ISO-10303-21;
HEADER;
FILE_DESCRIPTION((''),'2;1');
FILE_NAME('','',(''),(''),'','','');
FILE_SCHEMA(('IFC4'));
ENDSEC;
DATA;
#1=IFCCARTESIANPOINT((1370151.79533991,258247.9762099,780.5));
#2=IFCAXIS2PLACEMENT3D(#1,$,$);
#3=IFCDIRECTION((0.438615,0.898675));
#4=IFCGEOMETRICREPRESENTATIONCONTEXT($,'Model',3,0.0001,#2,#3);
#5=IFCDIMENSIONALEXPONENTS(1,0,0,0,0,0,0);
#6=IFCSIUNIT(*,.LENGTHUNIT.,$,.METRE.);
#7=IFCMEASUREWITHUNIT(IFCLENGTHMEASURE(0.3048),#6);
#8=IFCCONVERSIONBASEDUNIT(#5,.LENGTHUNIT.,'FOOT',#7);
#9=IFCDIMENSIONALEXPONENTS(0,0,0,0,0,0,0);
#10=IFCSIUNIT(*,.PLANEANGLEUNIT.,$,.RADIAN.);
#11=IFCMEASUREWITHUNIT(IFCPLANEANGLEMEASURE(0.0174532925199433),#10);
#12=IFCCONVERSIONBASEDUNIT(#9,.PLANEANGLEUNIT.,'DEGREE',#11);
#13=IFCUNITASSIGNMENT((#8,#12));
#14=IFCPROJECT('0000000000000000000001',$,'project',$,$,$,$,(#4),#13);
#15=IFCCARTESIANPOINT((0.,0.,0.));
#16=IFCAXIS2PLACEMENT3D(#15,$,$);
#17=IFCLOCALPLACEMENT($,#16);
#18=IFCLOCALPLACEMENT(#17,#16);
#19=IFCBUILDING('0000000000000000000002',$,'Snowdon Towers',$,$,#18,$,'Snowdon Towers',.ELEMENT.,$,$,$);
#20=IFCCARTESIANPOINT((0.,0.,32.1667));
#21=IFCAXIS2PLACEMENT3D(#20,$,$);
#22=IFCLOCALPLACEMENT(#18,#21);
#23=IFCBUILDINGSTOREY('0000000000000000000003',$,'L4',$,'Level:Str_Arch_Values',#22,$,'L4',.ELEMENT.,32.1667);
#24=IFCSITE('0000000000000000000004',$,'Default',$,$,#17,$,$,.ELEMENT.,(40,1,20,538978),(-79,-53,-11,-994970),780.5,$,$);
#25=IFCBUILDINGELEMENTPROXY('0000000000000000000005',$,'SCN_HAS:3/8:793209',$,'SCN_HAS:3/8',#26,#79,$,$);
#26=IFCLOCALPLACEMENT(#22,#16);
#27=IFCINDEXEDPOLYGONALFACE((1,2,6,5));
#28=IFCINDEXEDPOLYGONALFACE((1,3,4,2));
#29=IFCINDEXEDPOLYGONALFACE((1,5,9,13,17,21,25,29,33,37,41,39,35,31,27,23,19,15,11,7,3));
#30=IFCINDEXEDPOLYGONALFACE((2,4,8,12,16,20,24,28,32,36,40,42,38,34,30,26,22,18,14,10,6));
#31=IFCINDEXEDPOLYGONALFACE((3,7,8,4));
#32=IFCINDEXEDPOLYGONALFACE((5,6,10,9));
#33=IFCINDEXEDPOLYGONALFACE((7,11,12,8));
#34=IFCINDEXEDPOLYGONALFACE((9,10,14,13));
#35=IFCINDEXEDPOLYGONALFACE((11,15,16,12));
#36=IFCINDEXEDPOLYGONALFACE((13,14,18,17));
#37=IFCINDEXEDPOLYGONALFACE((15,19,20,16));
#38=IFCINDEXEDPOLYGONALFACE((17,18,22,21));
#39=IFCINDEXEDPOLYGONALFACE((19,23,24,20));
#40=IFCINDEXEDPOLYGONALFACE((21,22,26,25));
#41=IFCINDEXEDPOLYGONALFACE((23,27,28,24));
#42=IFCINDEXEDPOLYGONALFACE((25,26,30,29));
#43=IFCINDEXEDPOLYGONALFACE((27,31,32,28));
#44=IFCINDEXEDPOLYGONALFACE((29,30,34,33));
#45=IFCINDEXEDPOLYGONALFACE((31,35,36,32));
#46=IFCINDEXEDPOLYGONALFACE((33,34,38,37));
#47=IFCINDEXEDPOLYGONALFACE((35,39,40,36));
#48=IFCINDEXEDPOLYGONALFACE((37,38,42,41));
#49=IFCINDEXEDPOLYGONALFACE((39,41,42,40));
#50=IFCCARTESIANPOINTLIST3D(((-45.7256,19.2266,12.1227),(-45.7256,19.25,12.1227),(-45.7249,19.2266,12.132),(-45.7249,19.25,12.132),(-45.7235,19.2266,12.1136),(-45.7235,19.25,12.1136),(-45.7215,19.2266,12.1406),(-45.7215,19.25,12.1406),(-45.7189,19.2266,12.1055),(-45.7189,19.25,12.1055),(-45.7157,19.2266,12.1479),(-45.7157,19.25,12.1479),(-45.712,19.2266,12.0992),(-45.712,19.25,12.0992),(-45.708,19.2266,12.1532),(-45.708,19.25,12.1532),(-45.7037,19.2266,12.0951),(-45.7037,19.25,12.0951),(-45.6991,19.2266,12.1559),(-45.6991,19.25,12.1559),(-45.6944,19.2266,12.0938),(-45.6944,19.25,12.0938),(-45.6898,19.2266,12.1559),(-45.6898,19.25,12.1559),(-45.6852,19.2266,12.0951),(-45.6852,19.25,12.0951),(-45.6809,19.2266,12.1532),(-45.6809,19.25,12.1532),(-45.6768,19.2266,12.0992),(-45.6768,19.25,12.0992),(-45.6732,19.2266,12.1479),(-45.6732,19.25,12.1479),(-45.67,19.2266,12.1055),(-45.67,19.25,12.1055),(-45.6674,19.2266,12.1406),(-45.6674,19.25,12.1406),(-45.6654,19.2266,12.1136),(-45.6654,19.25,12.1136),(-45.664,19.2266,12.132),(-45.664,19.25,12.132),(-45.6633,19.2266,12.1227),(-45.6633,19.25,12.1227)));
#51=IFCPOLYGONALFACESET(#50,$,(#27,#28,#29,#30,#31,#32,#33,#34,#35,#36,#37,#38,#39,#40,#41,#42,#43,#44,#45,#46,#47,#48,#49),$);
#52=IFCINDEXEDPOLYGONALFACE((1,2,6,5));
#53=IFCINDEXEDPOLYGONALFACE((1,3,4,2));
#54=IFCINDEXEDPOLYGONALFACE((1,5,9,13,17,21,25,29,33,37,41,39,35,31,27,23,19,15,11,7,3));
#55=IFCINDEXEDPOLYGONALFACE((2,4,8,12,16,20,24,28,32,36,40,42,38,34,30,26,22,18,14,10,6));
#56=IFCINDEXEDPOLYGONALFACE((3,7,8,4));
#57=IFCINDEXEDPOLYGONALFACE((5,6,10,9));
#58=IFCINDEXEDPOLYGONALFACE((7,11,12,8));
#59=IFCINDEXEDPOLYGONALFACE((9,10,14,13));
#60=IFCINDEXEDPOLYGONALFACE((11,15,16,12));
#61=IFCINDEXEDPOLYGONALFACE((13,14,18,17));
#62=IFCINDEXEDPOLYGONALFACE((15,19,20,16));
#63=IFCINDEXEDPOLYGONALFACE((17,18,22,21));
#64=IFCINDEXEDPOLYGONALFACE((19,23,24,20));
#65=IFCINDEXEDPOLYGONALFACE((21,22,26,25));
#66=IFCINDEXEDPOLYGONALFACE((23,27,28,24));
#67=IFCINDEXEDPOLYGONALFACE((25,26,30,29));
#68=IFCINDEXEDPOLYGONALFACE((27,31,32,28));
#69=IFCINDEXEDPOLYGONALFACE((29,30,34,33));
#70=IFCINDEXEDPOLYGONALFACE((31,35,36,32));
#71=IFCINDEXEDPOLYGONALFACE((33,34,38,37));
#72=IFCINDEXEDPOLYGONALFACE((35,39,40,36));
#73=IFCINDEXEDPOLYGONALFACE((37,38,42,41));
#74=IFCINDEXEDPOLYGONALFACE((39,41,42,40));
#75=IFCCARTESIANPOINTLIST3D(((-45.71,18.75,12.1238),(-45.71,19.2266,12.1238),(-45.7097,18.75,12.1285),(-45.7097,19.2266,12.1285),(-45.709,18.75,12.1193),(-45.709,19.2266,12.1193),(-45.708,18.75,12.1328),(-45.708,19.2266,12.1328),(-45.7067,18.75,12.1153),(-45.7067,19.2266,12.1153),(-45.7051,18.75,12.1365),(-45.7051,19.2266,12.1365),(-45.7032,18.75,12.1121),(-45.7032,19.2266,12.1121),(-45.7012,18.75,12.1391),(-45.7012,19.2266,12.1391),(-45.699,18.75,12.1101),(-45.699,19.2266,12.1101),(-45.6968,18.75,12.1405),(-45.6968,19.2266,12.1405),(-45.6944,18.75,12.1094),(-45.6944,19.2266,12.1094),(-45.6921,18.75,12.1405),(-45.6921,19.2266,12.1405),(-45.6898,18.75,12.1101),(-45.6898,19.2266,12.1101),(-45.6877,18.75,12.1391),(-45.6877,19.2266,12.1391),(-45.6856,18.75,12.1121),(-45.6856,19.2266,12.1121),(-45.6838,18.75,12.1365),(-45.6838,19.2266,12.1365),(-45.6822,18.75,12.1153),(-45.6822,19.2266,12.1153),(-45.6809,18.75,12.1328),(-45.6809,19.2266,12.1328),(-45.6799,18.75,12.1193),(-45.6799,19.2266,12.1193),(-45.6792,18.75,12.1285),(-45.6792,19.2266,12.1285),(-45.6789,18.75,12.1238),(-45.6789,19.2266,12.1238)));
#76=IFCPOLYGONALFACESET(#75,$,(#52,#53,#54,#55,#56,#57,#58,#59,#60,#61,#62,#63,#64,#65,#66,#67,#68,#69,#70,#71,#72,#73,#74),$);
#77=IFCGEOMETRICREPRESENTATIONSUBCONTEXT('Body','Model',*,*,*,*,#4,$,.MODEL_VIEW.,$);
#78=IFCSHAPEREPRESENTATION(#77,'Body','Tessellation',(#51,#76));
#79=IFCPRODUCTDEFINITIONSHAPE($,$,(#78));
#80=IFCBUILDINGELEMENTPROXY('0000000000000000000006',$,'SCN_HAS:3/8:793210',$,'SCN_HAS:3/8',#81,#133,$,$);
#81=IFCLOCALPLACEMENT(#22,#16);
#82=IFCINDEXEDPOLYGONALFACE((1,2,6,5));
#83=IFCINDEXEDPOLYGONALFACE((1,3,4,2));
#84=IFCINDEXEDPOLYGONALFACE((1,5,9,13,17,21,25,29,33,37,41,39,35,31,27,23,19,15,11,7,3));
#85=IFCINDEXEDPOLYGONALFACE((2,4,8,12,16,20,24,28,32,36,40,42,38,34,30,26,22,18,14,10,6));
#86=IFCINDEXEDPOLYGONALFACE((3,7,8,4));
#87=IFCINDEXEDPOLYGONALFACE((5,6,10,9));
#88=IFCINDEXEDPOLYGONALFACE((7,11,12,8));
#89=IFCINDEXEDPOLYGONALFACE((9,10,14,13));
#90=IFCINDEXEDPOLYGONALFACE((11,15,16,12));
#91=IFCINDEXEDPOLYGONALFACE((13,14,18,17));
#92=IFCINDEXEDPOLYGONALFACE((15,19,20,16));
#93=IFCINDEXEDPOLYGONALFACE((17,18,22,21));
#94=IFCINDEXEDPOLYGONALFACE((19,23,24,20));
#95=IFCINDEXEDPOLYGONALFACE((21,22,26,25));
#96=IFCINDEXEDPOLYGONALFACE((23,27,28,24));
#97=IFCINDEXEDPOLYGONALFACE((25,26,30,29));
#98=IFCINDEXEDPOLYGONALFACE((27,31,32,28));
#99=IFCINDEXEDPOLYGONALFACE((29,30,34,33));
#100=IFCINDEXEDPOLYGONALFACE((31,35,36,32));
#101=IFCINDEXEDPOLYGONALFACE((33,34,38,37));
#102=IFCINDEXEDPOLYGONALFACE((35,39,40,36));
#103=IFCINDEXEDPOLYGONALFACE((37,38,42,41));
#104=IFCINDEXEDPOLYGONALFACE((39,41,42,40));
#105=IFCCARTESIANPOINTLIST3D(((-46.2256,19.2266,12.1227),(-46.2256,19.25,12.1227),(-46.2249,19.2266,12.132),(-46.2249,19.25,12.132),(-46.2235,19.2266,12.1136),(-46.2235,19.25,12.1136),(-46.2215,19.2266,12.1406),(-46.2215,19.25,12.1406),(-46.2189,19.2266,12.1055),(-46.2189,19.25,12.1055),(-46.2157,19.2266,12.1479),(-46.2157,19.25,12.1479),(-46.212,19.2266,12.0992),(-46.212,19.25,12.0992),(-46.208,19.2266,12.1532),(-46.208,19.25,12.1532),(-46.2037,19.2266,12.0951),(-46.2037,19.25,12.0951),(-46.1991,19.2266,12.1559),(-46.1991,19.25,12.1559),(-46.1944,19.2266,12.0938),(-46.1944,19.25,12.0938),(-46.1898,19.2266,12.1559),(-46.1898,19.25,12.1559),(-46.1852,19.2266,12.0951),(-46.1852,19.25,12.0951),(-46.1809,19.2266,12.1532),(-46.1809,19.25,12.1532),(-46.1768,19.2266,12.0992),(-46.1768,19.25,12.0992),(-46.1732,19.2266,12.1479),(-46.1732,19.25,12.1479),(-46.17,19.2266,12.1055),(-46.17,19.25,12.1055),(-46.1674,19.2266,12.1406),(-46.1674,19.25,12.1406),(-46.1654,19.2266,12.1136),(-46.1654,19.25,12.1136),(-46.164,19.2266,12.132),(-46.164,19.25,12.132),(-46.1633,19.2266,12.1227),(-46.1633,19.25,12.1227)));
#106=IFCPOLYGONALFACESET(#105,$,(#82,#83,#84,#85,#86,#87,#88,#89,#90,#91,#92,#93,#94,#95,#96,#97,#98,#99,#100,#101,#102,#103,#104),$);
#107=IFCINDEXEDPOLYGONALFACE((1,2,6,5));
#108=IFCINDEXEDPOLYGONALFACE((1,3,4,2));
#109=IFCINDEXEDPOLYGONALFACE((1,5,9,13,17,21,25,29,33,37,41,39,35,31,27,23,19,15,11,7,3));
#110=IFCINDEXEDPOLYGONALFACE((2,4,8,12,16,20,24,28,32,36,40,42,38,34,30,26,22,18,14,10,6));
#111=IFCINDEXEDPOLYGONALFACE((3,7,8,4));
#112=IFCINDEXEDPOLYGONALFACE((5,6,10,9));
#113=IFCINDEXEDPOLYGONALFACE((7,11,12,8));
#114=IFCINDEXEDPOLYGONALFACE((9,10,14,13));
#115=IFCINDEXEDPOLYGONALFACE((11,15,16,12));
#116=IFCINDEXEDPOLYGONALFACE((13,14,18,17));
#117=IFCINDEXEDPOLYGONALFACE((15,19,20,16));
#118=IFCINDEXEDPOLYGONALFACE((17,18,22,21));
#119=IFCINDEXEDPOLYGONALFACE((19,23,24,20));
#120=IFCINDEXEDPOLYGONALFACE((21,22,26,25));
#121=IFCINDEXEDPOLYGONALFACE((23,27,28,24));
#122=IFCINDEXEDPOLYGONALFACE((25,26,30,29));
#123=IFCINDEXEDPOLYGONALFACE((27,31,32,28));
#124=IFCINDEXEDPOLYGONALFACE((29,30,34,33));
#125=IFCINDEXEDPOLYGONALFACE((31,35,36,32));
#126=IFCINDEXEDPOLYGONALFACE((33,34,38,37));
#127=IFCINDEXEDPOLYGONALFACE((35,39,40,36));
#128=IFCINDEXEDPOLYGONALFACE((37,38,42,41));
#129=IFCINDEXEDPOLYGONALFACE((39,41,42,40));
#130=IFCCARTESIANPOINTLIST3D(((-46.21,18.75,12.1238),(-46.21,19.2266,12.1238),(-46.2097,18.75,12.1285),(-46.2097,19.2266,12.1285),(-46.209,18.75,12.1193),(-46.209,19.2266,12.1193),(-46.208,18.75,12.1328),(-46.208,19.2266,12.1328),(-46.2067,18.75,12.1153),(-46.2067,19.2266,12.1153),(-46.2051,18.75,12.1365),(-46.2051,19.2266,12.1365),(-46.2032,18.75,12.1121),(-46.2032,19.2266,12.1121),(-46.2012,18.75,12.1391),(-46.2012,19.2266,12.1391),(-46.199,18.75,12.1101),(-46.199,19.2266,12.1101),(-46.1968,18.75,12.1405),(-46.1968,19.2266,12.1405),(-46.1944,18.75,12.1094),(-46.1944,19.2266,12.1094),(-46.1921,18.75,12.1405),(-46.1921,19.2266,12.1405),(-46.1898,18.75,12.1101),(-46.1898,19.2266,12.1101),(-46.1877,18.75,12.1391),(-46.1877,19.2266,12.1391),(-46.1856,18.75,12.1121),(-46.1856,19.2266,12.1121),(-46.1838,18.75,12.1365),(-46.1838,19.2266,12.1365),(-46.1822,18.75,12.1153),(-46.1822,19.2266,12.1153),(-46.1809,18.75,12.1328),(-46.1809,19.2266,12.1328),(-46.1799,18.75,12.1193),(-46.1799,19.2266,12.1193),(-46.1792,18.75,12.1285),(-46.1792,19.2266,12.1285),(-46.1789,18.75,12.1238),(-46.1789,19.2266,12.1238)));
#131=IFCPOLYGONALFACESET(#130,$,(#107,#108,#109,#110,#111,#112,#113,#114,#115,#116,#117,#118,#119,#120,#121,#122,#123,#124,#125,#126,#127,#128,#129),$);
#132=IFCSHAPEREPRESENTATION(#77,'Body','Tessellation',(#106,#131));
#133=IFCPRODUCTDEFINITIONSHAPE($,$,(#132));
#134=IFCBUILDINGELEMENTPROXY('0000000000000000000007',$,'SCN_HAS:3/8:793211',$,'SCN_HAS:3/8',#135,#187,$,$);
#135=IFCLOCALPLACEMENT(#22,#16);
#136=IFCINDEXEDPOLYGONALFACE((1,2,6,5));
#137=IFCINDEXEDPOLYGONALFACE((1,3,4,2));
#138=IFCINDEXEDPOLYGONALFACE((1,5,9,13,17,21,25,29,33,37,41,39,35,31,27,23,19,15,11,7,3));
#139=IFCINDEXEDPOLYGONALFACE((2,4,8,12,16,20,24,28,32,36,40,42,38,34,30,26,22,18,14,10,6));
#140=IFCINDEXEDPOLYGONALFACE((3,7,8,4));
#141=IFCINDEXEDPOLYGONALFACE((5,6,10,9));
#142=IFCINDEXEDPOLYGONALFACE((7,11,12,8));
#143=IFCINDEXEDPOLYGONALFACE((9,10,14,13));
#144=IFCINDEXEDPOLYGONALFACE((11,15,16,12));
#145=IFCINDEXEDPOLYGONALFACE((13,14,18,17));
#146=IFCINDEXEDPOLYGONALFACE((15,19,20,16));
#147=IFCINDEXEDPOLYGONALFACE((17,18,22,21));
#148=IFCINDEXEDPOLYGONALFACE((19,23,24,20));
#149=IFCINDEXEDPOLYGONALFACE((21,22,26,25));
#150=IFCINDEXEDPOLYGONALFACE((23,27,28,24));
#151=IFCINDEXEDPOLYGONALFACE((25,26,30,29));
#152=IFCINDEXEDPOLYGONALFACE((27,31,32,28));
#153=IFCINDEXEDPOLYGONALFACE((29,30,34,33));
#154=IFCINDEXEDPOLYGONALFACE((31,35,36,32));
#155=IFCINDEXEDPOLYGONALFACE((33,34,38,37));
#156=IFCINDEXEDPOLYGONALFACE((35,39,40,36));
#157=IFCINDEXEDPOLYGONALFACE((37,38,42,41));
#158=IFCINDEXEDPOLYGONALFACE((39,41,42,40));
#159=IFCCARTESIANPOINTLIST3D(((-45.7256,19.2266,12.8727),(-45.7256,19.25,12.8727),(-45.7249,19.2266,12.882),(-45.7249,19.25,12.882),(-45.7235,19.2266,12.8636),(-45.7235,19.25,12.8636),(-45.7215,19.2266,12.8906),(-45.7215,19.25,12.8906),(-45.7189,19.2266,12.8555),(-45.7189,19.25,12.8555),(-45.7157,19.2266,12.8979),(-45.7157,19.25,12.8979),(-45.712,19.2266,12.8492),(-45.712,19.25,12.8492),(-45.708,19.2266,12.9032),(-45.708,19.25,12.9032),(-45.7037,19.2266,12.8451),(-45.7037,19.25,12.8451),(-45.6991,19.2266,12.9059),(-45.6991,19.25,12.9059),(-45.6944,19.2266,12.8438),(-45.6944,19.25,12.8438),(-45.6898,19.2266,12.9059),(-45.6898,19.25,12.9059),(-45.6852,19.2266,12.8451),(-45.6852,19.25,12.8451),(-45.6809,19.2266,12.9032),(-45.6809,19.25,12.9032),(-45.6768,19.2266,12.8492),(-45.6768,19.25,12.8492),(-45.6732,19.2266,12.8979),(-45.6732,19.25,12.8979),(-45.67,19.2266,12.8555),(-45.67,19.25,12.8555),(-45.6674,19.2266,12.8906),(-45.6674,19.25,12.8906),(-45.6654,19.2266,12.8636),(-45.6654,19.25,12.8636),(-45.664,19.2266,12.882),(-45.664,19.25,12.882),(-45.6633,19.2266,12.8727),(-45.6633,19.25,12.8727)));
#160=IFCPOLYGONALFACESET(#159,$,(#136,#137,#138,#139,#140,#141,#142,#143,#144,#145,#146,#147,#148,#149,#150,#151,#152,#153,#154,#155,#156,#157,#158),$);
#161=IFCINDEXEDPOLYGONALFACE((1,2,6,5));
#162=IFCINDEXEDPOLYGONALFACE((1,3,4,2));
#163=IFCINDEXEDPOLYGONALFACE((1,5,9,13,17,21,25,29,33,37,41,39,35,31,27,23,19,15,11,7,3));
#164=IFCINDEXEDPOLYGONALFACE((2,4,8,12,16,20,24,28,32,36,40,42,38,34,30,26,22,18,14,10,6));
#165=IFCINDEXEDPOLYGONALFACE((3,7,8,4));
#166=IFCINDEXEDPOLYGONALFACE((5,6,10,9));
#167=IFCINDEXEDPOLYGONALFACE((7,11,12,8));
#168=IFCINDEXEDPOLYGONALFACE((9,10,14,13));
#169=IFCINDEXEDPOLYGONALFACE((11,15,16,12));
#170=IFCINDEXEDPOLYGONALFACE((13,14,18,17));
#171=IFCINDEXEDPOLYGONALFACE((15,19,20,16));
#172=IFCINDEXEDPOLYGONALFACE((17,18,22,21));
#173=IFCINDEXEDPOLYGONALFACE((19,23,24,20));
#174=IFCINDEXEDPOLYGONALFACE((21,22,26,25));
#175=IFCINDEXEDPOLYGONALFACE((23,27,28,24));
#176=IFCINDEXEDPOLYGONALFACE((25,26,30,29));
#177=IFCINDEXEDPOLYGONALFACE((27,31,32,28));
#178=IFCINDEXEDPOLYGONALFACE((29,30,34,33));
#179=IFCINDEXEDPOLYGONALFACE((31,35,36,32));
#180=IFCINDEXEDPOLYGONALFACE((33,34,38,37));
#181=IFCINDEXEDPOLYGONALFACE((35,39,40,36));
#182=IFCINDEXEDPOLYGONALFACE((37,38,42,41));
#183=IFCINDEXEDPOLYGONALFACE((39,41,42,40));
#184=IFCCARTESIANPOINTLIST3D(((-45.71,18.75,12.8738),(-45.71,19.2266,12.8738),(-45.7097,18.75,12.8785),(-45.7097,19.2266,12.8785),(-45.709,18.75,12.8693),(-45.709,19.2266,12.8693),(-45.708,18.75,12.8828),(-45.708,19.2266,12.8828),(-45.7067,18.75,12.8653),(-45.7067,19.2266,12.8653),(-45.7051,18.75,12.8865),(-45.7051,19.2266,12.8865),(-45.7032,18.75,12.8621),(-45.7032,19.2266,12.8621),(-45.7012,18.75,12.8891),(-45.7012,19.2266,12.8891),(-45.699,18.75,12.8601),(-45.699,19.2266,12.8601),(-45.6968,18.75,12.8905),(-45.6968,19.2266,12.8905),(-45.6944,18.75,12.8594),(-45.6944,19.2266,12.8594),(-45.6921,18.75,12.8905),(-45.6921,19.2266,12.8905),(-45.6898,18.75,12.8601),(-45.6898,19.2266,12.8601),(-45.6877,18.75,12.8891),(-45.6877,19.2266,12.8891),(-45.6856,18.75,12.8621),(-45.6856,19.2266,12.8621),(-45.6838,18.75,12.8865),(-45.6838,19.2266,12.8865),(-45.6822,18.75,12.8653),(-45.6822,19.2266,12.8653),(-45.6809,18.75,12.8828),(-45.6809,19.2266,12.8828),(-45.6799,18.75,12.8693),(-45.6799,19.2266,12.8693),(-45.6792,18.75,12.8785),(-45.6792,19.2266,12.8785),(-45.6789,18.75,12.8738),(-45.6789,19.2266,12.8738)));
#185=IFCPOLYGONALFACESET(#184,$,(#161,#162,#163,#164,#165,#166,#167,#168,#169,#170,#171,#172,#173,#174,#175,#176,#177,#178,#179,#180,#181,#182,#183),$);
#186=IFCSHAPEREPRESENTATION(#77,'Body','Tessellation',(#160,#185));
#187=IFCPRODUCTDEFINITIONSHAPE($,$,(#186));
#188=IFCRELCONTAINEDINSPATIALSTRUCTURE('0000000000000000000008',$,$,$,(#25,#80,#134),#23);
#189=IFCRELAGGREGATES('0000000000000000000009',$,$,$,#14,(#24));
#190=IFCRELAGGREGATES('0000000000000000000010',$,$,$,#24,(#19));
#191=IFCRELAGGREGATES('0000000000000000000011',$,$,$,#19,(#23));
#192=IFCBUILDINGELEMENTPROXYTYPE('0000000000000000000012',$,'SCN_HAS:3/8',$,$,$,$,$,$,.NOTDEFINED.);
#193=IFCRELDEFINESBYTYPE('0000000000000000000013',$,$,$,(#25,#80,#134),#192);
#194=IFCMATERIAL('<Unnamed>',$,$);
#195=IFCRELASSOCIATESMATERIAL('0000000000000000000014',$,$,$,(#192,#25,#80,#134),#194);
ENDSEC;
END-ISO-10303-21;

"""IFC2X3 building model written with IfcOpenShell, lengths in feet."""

from ifc_helpers import new_model, entity, si_unit, converted_unit, direction, frame, frame_2d, origin, place, context, subcontext, project, spatial, circle, extrude, source, transform, mapped, material, type_object, type_shapes, element, save


model = new_model("IFC2X3")

# Units and contexts
model_context = context("Model", 3, precision=0.0001, world=frame((1370151.79533991, 258247.9762099, 780.5)), true_north=direction((0.438615, 0.898675)))
body_context = subcontext(model_context, "Body", "Model", "MODEL_VIEW")
ifc_project = project(units=[converted_unit("LENGTHUNIT", "FOOT", entity("IfcLengthMeasure", 0.3048), si_unit("LENGTHUNIT", "METRE"), dimensions=[1, 0, 0, 0, 0, 0, 0]), converted_unit("PLANEANGLEUNIT", "DEGREE", entity("IfcPlaneAngleMeasure", 0.0174532925199433), si_unit("PLANEANGLEUNIT", "RADIAN"), dimensions=[0, 0, 0, 0, 0, 0, 0])], contexts=[model_context])

# Site, building, storey
site_placement = place(None, origin())
site = spatial("IfcSite", under=ifc_project, at=site_placement, Name="Default", CompositionType="ELEMENT", RefLatitude=(40, 1, 20, 538978), RefLongitude=(-79, -53, -11, -994970), RefElevation=780.5)
building_placement = place(site_placement, origin())
building = spatial("IfcBuilding", under=site, at=building_placement, Name="Snowdon Towers", LongName="Snowdon Towers", CompositionType="ELEMENT")
storey_placement = place(building_placement, frame((0.0, 0.0, 32.1667)))
storey = spatial("IfcBuildingStorey", under=building, at=storey_placement, Name="L4", ObjectType="Level:Str_Arch_Values", LongName="L4", CompositionType="ELEMENT", Elevation=32.1667)

# Building element proxies
ifc_material_1 = material(Name="<Unnamed>")
building_element_proxy_type = type_object("IfcBuildingElementProxyType", Name="SCN_HAS:3/8", PredefinedType="NOTDEFINED", material=ifc_material_1)
shared_shape = source(origin(), body_context, "Body", "SweptSolid", [
    extrude(circle(Radius=0.0312, at=frame_2d((0.0, 0.0), x_axis=(1.0, 0.0))), frame((0.0, 0.0, -0.5), z_axis=(0.0, 0.0, 1.0), x_axis=(0.0, -1.0, 0.0)), (0.0, 0.0, 1.0), 0.0234),
    extrude(circle(Radius=0.0156, at=frame_2d((0.0, 0.0), x_axis=(1.0, 0.0))), frame((0.0, 0.0, -0.4766), z_axis=(0.0, 0.0, 1.0), x_axis=(0.0, -1.0, 0.0)), (0.0, 0.0, 1.0), 0.4766),
])
type_shapes(building_element_proxy_type, [shared_shape])
for number, where, z_axis, x_axis, name in (
    (1, (-45.6944, 18.75, 12.125), (0.0, -1.0, 0.0), (1.0, 0.0, 0.0), "SCN_HAS:3/8:793209"),
    (2, (-46.1944, 18.75, 12.125), (0.0, -1.0, 0.0), (1.0, 0.0, 0.0), "SCN_HAS:3/8:793210"),
    (3, (-45.6944, 18.75, 12.875), (0.0, -1.0, 0.0), (1.0, 0.0, 0.0), "SCN_HAS:3/8:793211"),
):
    element("IfcBuildingElementProxy", number, at=place(storey_placement, frame(where, z_axis=z_axis, x_axis=x_axis)), inside=storey, type_object=building_element_proxy_type, material=ifc_material_1, Name=name, ObjectType="SCN_HAS:3/8", context=body_context, shape_type="MappedRepresentation", body=[
        mapped(shared_shape, transform((0.0, 0.0, 0.0), scale=1.0)),
    ])

save(model, "model.ifc")
